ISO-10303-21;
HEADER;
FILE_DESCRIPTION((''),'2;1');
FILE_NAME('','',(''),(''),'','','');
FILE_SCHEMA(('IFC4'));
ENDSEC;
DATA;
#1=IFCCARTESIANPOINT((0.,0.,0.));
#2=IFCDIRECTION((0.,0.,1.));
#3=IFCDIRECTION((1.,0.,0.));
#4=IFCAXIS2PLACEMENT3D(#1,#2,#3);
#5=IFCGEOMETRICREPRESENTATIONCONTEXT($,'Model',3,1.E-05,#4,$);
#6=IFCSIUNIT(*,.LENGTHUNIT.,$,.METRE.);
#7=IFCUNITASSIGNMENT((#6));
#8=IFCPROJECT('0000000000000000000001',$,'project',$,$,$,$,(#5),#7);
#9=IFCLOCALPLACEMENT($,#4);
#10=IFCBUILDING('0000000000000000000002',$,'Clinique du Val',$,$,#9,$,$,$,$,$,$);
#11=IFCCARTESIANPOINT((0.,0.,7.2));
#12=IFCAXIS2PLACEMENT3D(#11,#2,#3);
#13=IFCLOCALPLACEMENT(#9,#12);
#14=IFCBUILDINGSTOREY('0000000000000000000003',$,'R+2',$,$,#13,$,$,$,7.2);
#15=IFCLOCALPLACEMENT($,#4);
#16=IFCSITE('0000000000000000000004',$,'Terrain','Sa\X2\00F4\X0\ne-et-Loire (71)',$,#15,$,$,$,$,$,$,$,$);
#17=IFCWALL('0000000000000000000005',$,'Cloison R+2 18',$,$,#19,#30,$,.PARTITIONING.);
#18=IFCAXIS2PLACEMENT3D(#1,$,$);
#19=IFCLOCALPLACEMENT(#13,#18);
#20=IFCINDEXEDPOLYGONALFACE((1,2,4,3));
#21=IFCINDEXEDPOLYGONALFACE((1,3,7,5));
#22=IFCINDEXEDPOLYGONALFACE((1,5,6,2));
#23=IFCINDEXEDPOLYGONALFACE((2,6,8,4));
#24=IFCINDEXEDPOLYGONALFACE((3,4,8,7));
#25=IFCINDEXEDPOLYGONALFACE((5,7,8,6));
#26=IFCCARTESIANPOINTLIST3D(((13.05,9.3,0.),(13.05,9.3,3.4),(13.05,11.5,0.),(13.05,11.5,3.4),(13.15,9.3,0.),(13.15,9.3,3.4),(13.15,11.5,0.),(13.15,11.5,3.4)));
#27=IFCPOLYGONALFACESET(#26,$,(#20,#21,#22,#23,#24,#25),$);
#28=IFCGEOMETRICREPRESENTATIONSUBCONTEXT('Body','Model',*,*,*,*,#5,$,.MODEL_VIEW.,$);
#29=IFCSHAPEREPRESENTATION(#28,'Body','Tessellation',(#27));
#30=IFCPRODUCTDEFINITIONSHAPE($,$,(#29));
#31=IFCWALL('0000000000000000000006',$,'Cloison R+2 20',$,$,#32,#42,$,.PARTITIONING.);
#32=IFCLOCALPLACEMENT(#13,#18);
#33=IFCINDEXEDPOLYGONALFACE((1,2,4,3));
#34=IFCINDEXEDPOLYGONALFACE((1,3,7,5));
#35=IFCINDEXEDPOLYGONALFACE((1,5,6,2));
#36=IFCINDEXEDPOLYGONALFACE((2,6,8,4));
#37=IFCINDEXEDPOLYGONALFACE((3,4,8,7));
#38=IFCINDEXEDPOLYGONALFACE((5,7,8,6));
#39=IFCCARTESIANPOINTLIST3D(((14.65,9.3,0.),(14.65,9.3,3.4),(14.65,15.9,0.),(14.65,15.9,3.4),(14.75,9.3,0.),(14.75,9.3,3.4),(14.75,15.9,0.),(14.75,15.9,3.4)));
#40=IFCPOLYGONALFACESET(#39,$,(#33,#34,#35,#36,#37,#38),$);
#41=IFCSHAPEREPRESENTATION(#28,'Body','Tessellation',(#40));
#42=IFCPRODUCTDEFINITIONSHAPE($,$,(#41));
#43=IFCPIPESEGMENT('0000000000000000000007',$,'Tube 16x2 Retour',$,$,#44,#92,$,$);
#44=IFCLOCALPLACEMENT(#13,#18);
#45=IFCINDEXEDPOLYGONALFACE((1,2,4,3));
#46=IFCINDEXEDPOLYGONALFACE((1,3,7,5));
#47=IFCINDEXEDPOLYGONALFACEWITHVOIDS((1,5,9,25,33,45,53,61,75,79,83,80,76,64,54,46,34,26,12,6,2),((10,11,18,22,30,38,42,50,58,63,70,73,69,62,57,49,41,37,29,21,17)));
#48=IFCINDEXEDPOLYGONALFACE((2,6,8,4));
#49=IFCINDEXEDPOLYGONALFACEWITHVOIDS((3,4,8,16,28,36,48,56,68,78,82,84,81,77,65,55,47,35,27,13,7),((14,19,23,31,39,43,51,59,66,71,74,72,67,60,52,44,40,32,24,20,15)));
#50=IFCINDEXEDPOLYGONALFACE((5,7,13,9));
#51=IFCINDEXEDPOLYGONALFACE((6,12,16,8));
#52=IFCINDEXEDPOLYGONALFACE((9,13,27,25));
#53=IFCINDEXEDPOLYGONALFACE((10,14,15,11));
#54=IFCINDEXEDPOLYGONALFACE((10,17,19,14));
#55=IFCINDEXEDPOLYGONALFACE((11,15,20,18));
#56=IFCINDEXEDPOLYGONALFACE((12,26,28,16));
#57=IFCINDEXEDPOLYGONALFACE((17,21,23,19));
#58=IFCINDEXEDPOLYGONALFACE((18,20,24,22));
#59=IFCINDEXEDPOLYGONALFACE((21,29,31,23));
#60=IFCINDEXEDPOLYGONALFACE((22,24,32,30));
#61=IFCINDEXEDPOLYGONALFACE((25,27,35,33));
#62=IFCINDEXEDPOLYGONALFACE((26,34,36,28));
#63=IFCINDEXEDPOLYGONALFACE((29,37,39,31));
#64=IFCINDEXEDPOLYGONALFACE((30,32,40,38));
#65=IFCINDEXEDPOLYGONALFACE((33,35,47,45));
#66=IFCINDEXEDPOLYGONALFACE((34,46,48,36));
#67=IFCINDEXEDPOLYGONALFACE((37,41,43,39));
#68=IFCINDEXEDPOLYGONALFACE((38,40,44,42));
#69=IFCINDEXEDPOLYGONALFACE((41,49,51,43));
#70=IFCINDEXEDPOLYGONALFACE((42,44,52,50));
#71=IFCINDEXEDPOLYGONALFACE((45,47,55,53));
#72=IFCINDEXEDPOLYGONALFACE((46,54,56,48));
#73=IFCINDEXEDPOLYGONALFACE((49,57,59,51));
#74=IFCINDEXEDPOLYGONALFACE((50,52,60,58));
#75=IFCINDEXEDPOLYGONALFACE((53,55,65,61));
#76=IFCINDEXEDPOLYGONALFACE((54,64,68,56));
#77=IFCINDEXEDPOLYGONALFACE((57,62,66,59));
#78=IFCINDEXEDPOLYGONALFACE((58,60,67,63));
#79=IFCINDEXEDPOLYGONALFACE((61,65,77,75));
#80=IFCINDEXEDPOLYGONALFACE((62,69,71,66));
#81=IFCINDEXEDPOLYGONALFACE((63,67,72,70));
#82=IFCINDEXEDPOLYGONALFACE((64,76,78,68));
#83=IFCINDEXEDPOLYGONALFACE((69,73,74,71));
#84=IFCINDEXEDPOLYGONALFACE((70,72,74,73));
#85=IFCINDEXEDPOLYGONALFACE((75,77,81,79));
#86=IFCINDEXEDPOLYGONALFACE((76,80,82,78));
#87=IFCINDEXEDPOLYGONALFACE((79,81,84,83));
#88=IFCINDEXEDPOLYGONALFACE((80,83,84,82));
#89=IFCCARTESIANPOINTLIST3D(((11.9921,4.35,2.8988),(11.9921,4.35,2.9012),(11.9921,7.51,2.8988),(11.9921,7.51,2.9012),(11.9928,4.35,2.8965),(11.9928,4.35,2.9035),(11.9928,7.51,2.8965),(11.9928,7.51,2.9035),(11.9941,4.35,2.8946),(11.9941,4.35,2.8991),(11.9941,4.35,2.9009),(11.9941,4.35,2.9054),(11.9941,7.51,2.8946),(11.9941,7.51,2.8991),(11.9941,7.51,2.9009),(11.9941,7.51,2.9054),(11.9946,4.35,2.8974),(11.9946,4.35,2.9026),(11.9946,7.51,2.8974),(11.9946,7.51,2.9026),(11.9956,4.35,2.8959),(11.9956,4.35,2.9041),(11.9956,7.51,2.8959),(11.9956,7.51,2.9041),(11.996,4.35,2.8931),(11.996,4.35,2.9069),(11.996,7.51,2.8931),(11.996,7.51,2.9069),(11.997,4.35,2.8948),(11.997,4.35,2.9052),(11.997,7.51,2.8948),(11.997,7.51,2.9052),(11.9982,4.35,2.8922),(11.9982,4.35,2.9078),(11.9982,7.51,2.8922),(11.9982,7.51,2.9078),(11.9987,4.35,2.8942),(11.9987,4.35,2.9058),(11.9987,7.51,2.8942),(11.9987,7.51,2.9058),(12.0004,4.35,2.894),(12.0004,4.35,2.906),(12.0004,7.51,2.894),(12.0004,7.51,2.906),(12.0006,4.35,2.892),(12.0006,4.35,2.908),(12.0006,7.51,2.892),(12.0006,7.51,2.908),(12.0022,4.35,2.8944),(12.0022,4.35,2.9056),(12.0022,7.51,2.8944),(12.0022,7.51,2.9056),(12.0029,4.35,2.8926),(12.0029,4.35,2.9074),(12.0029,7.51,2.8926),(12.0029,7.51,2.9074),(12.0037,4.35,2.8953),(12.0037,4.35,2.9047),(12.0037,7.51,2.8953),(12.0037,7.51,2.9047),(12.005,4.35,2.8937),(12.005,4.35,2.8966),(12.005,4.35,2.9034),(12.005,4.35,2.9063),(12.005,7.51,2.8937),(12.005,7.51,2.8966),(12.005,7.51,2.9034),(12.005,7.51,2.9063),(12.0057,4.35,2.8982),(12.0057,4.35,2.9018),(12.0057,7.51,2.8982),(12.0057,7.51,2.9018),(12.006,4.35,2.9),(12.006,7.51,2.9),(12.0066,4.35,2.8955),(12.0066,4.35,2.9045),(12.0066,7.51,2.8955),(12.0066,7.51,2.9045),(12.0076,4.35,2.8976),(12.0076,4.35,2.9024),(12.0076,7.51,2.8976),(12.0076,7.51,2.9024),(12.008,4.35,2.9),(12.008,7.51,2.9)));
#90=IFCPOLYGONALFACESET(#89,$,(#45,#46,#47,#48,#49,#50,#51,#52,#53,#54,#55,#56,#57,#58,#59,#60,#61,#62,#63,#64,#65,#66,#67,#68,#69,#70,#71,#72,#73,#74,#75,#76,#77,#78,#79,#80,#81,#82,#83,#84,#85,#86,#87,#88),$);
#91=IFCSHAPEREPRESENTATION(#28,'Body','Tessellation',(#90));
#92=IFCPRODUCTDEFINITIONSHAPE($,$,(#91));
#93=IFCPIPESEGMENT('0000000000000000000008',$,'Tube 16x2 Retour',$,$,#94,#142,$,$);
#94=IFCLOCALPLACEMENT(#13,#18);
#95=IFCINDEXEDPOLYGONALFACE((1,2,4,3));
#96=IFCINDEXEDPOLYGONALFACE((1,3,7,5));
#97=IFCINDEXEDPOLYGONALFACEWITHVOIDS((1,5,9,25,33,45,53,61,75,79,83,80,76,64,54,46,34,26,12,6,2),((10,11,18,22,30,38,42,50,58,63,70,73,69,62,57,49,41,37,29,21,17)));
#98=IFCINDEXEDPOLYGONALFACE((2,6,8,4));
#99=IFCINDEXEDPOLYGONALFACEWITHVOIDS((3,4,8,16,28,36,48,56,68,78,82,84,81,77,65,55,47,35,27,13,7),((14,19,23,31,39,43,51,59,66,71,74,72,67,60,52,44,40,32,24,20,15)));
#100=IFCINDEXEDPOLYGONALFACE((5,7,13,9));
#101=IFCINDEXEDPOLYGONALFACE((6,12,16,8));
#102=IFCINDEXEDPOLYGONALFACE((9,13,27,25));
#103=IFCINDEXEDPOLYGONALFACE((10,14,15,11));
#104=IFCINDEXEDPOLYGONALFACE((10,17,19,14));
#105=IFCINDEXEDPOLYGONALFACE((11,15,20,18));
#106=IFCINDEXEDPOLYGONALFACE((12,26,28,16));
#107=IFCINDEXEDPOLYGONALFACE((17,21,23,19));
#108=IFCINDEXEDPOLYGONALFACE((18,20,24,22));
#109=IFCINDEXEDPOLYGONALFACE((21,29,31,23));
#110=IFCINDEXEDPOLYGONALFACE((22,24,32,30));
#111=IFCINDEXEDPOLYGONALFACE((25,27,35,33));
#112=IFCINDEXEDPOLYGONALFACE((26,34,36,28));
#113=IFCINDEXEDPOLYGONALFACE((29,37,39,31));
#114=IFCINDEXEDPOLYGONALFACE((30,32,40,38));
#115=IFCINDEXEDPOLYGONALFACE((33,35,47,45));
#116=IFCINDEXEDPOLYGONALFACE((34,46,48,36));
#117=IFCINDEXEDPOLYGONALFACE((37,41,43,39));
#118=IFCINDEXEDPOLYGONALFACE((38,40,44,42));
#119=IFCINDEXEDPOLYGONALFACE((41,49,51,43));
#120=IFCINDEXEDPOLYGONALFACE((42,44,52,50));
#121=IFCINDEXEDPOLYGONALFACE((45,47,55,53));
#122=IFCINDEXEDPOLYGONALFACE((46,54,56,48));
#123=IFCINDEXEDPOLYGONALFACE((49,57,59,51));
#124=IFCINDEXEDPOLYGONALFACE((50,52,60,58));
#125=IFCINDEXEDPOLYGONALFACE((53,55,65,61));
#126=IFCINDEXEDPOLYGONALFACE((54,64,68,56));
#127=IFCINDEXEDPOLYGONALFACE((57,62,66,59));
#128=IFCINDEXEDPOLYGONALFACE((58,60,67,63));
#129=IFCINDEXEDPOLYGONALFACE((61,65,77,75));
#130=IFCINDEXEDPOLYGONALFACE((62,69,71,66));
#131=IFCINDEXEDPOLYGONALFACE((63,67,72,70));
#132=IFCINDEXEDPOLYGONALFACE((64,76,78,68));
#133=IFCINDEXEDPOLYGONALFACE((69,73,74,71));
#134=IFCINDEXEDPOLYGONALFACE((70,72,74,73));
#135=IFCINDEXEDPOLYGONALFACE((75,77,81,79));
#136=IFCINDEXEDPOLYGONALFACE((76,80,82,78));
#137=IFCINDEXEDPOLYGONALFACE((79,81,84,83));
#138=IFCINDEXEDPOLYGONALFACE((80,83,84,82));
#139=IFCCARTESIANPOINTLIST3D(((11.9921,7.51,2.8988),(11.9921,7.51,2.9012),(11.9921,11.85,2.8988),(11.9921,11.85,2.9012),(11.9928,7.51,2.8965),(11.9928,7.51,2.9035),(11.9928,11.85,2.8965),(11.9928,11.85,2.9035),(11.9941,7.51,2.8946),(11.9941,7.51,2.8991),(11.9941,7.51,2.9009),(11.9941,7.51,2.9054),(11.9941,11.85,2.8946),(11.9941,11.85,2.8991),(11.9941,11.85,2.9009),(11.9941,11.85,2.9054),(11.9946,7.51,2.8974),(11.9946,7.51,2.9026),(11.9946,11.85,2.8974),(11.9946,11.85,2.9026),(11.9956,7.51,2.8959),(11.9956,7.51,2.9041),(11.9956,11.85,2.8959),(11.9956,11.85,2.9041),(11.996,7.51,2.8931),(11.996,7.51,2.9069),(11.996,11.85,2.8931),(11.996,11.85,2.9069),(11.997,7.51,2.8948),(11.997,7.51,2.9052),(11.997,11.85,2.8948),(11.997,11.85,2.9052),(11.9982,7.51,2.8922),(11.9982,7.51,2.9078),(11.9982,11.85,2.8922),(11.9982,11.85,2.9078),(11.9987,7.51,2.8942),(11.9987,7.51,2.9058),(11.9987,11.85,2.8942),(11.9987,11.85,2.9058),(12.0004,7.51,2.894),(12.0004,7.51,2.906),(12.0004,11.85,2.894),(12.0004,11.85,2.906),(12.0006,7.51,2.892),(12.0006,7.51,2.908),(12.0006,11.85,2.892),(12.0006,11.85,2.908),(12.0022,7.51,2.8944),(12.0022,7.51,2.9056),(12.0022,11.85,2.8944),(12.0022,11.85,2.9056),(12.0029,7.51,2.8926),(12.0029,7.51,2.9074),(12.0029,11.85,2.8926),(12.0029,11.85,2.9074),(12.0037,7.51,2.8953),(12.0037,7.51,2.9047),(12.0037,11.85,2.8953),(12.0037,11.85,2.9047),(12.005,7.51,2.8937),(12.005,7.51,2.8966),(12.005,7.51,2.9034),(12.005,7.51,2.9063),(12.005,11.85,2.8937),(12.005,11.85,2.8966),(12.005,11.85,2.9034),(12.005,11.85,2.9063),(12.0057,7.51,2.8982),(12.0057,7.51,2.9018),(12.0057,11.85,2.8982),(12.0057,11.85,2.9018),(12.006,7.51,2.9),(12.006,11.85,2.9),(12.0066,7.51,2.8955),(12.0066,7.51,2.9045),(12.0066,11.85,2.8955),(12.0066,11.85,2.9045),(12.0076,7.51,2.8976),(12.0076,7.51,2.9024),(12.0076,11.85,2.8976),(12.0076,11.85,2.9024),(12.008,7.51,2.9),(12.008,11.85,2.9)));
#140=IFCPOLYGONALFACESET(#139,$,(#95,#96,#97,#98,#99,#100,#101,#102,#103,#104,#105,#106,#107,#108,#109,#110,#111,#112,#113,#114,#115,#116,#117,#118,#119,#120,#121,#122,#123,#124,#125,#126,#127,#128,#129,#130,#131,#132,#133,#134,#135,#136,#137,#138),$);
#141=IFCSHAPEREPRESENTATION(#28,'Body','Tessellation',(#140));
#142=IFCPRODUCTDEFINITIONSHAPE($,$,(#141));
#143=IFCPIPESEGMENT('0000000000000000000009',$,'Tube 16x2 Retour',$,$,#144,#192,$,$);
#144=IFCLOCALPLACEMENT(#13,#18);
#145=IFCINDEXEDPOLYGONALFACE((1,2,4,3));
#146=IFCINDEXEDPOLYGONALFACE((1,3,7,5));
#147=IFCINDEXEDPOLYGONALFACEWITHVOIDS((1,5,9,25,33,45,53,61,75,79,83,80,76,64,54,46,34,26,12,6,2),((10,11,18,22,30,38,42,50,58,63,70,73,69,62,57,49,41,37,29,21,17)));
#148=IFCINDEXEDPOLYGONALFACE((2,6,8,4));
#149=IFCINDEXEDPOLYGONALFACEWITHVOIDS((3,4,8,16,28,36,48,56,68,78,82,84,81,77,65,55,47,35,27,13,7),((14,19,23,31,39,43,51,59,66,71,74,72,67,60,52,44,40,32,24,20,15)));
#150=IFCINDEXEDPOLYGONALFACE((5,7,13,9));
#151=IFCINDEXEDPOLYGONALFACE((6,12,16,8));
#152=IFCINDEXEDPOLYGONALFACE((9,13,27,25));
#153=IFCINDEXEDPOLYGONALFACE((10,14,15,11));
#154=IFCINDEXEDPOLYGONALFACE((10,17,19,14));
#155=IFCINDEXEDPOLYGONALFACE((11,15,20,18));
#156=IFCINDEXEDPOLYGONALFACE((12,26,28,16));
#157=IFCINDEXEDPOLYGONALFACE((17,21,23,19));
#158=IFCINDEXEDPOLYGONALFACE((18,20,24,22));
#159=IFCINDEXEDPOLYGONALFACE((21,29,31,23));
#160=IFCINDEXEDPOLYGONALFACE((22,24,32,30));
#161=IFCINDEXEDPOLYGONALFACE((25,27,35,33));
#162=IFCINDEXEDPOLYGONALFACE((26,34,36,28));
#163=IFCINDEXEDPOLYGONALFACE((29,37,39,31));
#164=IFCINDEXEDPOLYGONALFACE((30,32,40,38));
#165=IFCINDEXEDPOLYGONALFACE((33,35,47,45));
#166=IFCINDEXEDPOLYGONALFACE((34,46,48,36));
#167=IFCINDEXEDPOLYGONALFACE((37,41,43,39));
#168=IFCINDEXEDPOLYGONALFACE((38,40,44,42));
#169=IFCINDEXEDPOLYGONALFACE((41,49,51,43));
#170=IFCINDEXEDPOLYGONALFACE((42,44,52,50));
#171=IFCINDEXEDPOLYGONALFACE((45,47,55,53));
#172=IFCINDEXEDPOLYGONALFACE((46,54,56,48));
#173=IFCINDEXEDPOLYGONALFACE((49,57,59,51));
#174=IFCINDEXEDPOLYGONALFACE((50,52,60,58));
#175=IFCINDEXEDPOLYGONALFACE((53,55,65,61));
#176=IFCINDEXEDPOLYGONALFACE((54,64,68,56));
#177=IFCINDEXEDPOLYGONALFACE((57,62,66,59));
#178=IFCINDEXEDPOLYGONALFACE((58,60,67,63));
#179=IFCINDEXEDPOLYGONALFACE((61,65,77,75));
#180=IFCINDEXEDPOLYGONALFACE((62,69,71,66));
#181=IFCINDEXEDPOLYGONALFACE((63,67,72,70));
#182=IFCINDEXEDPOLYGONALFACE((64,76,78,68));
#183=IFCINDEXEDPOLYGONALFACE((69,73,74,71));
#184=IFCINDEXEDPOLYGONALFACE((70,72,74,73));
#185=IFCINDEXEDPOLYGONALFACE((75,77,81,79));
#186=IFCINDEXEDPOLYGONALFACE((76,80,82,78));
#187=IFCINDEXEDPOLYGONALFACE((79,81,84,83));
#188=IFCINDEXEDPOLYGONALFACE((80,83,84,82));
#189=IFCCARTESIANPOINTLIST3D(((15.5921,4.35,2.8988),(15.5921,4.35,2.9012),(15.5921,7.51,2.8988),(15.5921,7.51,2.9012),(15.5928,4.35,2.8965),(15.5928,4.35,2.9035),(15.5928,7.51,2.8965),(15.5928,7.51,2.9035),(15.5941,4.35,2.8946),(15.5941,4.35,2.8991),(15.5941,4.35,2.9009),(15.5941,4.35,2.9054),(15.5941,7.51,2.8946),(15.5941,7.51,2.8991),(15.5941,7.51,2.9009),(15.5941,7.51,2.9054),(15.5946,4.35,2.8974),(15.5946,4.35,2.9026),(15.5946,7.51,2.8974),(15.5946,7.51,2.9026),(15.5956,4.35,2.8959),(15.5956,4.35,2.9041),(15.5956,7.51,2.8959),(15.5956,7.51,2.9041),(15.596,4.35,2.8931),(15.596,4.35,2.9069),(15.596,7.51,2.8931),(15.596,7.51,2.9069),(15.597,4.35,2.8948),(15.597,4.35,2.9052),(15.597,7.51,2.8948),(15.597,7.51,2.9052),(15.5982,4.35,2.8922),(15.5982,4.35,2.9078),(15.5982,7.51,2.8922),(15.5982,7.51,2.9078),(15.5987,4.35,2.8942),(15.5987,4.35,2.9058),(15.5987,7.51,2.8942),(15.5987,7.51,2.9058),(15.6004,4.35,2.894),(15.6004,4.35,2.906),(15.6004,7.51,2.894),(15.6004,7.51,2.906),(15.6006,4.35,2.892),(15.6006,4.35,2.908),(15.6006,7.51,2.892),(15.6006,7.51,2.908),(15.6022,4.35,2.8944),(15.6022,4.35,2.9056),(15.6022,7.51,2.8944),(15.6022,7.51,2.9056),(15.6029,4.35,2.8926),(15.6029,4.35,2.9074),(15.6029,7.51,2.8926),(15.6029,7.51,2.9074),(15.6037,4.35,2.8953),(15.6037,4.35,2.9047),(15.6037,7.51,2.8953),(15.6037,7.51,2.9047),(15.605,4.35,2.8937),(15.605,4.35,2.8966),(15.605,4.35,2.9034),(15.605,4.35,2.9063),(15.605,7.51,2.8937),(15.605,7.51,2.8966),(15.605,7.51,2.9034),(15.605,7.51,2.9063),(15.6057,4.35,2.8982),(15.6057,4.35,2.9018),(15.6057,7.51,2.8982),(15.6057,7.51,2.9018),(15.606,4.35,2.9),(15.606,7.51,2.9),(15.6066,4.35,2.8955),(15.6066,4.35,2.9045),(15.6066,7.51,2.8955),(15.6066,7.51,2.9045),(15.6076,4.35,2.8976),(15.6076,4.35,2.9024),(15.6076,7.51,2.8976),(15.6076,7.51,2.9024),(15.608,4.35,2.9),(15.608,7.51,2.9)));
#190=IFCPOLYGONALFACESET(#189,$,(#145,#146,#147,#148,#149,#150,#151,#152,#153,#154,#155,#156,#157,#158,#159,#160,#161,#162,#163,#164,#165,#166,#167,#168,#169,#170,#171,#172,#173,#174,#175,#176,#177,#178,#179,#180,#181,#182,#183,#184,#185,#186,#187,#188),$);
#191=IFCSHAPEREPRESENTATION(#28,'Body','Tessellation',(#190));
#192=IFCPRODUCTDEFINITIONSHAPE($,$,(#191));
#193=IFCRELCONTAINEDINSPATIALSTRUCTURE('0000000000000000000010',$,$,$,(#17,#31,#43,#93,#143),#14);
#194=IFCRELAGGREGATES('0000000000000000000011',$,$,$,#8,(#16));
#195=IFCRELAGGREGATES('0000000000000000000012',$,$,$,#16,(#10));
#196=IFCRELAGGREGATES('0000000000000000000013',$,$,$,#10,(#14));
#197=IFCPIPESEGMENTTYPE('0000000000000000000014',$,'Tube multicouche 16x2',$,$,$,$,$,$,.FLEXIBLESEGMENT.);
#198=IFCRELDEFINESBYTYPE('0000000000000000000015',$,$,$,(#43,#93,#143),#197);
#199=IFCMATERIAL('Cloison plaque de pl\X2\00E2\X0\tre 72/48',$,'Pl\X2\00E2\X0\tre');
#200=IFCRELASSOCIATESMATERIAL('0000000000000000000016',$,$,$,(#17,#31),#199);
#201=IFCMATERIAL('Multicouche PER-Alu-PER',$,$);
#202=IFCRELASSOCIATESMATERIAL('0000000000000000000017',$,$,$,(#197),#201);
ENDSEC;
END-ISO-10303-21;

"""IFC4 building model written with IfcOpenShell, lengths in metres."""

from ifc_helpers import new_model, si_unit, frame, frame_2d, origin_with_axes, place, context, subcontext, project, spatial, rectangle, hollow_circle, extrude, material, type_object, element, save


model = new_model("IFC4")

# Units and contexts
model_context = context("Model", 3, precision=1e-05, world=origin_with_axes())
body_context = subcontext(model_context, "Body", "Model", "MODEL_VIEW")
ifc_project = project(units=[si_unit("LENGTHUNIT", "METRE")], contexts=[model_context])

# Site, building, storey
site_placement = place(None, origin_with_axes())
site = spatial("IfcSite", under=ifc_project, at=site_placement, Name="Terrain", Description="Saône-et-Loire (71)")
building_placement = place(None, origin_with_axes())
building = spatial("IfcBuilding", under=site, at=building_placement, Name="Clinique du Val")
storey_placement = place(building_placement, frame((0.0, 0.0, 7.2), z_axis=(0.0, 0.0, 1.0), x_axis=(1.0, 0.0, 0.0)))
storey = spatial("IfcBuildingStorey", under=building, at=storey_placement, Name="R+2", Elevation=7.2)

# Walls
ifc_material_1 = material(Name="Cloison plaque de plâtre 72/48", Category="Plâtre")
wall_1_placement = place(storey_placement, frame((13.05, 9.3, 0.0), z_axis=(0.0, 0.0, 1.0), x_axis=(1.0, 0.0, 0.0)))
element("IfcWall", 1, at=wall_1_placement, inside=storey, material=ifc_material_1, Name="Cloison R+2 18", PredefinedType="PARTITIONING", context=body_context, shape_type="SweptSolid", body=[
    extrude(rectangle(XDim=0.1, YDim=2.2, at=frame_2d((0.05, 1.1))), origin_with_axes(), (0.0, 0.0, 1.0), 3.4),
])
wall_2_placement = place(storey_placement, frame((14.65, 9.3, 0.0), z_axis=(0.0, 0.0, 1.0), x_axis=(1.0, 0.0, 0.0)))
element("IfcWall", 2, at=wall_2_placement, inside=storey, material=ifc_material_1, Name="Cloison R+2 20", PredefinedType="PARTITIONING", context=body_context, shape_type="SweptSolid", body=[
    extrude(rectangle(XDim=0.1, YDim=6.6, at=frame_2d((0.05, 3.3))), origin_with_axes(), (0.0, 0.0, 1.0), 3.4),
])

# Pipe segments
ifc_material_2 = material(Name="Multicouche PER-Alu-PER")
pipe_segment_type_1 = type_object("IfcPipeSegmentType", Name="Tube multicouche 16x2", PredefinedType="FLEXIBLESEGMENT", material=ifc_material_2)
pipe_segment_1_placement = place(storey_placement, frame((12.0, 7.51, 2.9), z_axis=(0.0, -1.0, 0.0), x_axis=(1.0, 0.0, 0.0)))
element("IfcPipeSegment", 3, at=pipe_segment_1_placement, inside=storey, type_object=pipe_segment_type_1, Name="Tube 16x2 Retour", context=body_context, shape_type="SweptSolid", body=[
    extrude(hollow_circle(Radius=0.008, WallThickness=0.002), origin_with_axes(), (0.0, 0.0, 1.0), 3.16),
])
pipe_segment_2_placement = place(storey_placement, frame((12.0, 7.51, 2.9), z_axis=(0.0, 1.0, 0.0), x_axis=(1.0, 0.0, 0.0)))
element("IfcPipeSegment", 4, at=pipe_segment_2_placement, inside=storey, type_object=pipe_segment_type_1, Name="Tube 16x2 Retour", context=body_context, shape_type="SweptSolid", body=[
    extrude(hollow_circle(Radius=0.008, WallThickness=0.002), origin_with_axes(), (0.0, 0.0, 1.0), 4.34),
])
pipe_segment_3_placement = place(storey_placement, frame((15.6, 7.51, 2.9), z_axis=(0.0, -1.0, 0.0), x_axis=(1.0, 0.0, 0.0)))
element("IfcPipeSegment", 5, at=pipe_segment_3_placement, inside=storey, type_object=pipe_segment_type_1, Name="Tube 16x2 Retour", context=body_context, shape_type="SweptSolid", body=[
    extrude(hollow_circle(Radius=0.008, WallThickness=0.002), origin_with_axes(), (0.0, 0.0, 1.0), 3.16),
])

save(model, "model.ifc")
